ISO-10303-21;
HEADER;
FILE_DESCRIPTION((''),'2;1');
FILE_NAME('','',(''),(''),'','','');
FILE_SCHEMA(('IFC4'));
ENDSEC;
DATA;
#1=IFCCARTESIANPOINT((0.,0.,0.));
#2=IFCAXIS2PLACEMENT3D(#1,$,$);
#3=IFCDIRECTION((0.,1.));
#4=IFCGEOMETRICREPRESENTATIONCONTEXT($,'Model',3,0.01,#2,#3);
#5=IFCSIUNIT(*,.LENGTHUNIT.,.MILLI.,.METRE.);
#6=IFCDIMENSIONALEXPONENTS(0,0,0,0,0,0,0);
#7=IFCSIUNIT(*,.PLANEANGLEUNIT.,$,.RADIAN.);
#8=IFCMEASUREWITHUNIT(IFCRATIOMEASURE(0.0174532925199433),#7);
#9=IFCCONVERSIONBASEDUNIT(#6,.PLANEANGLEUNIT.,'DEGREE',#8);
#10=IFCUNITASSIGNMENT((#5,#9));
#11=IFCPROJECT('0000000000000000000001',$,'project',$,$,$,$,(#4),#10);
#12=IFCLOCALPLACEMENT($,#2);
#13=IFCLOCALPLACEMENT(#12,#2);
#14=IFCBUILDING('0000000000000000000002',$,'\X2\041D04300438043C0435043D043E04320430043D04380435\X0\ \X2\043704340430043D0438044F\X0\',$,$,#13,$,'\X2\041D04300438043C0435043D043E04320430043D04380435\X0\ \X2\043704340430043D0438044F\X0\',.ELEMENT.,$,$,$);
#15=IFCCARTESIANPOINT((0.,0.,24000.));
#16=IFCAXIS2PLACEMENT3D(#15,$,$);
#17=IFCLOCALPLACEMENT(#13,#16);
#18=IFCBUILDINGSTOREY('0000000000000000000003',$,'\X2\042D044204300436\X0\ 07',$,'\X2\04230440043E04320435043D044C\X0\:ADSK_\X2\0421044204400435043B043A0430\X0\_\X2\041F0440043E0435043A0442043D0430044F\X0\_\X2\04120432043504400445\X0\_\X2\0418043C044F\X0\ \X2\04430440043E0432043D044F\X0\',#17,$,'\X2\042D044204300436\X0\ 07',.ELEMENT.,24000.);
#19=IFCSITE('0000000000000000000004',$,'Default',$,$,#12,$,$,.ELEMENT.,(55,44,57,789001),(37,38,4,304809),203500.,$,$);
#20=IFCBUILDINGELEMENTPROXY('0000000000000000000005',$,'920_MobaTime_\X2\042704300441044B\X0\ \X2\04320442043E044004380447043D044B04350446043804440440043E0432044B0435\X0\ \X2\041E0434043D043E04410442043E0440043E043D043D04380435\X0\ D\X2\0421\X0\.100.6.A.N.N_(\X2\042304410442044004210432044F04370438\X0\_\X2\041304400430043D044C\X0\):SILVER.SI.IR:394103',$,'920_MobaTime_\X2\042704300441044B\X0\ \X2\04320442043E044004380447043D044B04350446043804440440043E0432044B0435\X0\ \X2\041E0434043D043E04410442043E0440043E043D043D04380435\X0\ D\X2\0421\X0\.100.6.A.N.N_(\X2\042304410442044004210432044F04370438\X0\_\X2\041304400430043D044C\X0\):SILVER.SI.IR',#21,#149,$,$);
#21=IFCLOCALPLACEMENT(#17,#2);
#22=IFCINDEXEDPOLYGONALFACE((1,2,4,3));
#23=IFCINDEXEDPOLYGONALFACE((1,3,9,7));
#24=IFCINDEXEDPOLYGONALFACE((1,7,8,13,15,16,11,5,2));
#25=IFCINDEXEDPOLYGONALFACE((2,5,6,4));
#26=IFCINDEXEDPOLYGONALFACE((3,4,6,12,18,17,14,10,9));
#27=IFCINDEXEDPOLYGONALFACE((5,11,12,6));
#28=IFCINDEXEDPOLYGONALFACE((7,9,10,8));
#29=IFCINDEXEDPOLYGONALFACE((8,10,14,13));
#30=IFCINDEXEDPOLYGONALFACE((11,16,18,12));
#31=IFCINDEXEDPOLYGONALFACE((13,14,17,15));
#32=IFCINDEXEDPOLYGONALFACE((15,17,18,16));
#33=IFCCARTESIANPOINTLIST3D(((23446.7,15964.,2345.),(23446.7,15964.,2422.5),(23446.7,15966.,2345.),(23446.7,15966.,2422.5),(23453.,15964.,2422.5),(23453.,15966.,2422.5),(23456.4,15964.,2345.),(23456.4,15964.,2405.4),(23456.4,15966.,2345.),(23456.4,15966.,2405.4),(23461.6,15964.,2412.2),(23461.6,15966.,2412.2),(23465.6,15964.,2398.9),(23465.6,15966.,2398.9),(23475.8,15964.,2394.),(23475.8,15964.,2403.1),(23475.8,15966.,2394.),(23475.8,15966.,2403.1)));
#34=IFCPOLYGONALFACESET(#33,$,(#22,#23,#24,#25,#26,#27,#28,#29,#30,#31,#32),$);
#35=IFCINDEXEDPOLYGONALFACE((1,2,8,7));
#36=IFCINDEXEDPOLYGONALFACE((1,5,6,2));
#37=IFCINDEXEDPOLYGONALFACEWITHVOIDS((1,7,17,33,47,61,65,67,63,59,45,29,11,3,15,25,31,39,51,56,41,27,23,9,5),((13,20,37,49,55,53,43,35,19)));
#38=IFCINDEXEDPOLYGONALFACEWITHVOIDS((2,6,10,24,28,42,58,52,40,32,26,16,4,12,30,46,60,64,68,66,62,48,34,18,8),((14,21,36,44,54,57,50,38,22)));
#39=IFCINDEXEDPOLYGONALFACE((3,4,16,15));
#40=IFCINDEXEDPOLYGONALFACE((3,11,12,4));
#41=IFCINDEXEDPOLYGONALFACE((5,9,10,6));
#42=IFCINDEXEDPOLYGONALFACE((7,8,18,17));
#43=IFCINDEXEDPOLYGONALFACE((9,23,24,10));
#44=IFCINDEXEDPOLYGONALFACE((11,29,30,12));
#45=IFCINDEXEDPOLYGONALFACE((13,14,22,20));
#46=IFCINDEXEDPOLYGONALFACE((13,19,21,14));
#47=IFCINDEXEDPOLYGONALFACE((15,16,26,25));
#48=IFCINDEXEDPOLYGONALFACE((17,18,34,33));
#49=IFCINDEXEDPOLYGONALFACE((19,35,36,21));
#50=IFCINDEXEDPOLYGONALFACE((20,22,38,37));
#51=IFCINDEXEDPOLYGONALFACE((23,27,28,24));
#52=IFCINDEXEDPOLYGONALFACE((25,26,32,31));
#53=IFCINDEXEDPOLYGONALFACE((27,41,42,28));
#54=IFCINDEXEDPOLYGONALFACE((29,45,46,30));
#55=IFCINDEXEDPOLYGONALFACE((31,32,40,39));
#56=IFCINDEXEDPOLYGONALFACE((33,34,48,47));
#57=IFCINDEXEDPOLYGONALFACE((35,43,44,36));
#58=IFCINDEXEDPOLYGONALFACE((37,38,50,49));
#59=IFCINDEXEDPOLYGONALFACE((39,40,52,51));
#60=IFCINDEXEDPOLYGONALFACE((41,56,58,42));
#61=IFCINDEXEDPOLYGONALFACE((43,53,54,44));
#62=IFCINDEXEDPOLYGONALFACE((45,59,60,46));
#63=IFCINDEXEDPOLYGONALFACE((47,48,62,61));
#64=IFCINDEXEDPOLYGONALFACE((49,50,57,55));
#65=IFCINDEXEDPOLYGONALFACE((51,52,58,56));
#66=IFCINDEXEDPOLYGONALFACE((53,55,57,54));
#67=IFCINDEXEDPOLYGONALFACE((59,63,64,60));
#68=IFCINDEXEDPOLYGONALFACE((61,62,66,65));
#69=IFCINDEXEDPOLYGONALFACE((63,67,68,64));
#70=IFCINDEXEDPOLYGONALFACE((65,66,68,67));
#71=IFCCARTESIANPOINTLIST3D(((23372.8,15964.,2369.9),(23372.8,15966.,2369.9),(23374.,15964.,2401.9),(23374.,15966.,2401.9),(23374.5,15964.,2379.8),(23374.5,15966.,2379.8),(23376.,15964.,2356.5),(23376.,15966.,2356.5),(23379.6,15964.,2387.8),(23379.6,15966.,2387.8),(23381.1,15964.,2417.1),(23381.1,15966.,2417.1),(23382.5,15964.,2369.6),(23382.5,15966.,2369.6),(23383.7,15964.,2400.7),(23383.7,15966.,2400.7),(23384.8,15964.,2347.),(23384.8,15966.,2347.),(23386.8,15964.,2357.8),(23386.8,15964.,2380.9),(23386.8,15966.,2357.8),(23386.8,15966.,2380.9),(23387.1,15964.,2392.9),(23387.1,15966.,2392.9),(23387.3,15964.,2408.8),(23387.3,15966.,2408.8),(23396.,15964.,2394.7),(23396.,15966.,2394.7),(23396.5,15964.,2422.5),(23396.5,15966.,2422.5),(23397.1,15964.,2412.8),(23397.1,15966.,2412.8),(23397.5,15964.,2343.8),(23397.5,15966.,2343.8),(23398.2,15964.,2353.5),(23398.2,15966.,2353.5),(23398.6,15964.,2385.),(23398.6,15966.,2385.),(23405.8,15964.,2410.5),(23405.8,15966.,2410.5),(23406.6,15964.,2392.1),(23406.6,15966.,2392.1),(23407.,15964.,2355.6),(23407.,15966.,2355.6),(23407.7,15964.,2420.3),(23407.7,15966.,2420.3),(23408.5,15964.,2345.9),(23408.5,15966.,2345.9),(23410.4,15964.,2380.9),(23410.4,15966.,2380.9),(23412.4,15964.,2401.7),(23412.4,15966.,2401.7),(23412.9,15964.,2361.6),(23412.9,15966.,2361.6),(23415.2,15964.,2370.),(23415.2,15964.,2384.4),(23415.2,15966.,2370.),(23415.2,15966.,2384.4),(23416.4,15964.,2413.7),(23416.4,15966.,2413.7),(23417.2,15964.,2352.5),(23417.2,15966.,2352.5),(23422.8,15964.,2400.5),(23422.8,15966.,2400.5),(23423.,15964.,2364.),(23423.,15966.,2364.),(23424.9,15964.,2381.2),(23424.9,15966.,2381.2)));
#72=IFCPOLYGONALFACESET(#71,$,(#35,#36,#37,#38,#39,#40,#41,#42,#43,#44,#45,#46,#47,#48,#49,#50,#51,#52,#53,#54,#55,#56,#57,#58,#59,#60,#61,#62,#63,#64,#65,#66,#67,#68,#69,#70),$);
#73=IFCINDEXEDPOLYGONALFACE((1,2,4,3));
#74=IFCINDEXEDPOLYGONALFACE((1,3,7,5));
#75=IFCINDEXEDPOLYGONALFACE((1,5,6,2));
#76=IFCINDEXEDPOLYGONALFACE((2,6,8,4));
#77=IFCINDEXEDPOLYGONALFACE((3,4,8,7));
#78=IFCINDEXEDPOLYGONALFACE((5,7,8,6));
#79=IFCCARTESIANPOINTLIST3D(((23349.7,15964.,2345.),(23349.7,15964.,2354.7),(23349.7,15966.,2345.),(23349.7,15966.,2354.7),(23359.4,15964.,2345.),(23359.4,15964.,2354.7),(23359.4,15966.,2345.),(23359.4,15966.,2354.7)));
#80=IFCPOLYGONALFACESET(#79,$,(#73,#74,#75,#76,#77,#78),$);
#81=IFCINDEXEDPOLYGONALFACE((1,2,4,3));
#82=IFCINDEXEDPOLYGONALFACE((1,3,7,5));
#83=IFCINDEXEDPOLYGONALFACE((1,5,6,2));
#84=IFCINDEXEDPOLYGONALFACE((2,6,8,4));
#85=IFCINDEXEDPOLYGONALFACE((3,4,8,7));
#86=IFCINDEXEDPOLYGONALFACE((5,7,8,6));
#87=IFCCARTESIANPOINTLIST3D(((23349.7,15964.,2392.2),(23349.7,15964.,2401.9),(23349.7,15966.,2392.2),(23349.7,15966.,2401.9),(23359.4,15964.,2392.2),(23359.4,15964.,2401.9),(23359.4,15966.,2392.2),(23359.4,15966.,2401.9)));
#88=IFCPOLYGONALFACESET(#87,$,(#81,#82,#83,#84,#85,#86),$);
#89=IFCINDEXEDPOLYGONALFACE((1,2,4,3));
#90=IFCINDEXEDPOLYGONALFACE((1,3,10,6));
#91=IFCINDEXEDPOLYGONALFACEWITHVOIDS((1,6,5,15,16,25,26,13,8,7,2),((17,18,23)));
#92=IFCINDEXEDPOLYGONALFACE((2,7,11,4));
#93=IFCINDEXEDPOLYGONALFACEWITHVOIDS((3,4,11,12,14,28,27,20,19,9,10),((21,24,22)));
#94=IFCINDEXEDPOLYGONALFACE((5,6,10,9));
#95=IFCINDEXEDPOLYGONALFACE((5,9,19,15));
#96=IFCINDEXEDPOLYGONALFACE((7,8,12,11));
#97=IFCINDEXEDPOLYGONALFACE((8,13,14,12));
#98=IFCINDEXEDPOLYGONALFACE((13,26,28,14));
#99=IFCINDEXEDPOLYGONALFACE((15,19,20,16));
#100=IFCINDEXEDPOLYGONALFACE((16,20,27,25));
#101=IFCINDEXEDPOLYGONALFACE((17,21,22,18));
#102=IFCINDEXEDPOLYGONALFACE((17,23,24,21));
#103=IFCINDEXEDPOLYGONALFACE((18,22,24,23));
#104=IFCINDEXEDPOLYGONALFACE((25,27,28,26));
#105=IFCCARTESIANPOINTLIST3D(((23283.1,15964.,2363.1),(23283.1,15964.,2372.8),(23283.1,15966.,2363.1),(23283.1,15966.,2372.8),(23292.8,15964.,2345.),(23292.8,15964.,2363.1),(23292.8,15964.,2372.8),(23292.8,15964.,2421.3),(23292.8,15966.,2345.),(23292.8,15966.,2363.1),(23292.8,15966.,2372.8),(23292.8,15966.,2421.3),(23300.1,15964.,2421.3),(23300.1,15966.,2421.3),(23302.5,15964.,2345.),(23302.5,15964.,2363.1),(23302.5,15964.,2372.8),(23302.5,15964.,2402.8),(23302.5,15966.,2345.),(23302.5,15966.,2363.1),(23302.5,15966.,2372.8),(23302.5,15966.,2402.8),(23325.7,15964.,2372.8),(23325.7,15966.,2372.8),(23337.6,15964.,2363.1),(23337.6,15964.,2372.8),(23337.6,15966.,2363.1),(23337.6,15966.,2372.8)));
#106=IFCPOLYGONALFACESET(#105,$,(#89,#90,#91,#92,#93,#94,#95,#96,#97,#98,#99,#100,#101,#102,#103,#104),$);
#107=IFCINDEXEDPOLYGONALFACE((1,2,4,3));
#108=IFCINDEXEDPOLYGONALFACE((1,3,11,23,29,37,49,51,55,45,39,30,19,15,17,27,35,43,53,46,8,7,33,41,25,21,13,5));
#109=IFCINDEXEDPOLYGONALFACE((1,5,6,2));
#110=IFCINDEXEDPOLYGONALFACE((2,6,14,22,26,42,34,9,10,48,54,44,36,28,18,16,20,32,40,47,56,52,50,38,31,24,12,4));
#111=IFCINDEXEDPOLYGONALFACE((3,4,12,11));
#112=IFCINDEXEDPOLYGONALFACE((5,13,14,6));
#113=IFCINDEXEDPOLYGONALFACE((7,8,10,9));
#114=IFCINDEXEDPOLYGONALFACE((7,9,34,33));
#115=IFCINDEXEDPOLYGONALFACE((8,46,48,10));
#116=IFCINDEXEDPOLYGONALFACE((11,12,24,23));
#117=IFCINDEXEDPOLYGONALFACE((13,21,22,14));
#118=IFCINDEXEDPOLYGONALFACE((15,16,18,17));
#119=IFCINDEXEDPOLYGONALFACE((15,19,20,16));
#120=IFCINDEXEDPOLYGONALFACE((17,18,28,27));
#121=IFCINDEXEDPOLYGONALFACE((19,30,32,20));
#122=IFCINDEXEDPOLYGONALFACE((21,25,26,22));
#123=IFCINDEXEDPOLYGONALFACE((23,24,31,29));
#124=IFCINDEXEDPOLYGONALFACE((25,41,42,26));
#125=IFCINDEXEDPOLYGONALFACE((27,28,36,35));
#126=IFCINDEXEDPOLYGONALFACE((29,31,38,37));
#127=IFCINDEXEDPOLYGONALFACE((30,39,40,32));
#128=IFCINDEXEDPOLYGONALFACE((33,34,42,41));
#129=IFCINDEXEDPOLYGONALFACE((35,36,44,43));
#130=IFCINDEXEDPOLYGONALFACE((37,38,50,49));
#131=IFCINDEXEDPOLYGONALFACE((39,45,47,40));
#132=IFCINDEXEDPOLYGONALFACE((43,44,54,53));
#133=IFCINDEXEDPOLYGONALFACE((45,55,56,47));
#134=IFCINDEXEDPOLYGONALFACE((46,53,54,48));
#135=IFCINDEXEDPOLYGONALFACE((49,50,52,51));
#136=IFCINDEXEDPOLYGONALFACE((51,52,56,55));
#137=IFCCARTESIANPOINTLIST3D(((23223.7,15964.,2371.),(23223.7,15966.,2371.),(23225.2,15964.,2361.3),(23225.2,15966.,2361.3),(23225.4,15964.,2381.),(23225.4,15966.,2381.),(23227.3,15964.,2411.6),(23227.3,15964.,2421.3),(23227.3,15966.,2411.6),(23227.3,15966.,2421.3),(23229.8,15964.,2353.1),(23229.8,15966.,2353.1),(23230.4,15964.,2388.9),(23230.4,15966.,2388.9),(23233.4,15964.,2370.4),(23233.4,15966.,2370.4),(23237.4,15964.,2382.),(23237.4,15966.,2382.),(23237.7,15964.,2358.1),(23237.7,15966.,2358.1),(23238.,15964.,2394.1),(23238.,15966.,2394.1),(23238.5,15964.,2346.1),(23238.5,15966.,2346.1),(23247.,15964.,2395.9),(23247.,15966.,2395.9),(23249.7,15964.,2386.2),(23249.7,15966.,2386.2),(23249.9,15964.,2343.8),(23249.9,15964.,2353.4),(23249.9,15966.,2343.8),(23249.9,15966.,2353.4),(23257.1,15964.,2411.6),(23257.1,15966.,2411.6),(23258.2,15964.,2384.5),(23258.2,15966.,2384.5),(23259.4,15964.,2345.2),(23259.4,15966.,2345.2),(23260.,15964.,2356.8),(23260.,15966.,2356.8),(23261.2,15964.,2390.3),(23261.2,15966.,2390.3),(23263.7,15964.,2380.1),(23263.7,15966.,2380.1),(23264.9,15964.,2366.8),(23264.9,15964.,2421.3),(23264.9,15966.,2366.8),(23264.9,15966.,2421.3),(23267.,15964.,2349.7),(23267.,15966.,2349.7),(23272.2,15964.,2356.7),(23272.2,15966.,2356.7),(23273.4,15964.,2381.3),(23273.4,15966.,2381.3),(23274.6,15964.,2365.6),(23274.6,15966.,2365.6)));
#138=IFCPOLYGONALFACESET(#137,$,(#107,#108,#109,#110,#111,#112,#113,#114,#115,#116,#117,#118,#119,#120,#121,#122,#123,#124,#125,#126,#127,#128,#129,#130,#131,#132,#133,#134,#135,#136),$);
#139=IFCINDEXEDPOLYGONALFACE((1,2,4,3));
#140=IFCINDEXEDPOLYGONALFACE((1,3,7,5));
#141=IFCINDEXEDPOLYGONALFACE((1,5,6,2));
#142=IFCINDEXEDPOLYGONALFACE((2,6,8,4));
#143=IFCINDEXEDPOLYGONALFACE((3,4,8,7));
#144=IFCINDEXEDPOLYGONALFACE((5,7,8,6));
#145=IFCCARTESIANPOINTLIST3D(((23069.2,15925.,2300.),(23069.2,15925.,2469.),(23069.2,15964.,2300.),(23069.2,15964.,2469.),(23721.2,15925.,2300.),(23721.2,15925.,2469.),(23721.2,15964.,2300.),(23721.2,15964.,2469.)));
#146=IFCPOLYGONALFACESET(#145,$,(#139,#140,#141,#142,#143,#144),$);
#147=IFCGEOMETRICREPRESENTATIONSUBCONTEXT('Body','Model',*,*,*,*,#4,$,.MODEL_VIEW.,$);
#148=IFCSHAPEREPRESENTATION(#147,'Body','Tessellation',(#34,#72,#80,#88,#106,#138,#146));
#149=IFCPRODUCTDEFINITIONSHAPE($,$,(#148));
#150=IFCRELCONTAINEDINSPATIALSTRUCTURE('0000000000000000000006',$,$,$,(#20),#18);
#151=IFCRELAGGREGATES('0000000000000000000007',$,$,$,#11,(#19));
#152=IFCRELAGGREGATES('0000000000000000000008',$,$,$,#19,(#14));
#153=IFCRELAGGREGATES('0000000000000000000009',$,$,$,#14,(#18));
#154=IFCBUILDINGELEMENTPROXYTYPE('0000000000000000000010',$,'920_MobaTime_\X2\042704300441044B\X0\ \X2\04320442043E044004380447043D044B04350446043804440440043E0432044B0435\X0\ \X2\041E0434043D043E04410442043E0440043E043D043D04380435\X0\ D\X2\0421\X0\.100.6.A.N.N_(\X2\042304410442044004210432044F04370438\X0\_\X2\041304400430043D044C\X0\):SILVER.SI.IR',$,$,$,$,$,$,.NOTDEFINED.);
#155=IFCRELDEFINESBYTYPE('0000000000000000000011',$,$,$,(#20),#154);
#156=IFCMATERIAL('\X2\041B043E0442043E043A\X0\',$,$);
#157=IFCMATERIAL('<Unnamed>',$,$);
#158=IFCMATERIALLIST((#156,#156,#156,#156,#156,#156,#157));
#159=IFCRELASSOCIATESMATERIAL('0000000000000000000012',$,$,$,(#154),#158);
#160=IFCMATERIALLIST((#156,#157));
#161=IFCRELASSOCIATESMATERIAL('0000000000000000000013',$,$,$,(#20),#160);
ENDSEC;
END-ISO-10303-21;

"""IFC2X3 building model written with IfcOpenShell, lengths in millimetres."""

from ifc_helpers import new_model, entity, si_unit, converted_unit, direction, frame, origin, origin_2d_with_axis, place, context, subcontext, project, spatial, polyline, rectangle, outline, extrude, source, transform, mapped, material, material_list, type_object, type_shapes, element, save


model = new_model("IFC2X3")

# Units and contexts
model_context = context("Model", 3, precision=0.01, world=origin(), true_north=direction((0.0, 1.0)))
body_context = subcontext(model_context, "Body", "Model", "MODEL_VIEW")
ifc_project = project(units=[si_unit("LENGTHUNIT", "METRE", prefix="MILLI"), converted_unit("PLANEANGLEUNIT", "DEGREE", entity("IfcRatioMeasure", 0.0174532925199433), si_unit("PLANEANGLEUNIT", "RADIAN"), dimensions=[0, 0, 0, 0, 0, 0, 0])], contexts=[model_context])

# Site, building, storey
site_placement = place(None, origin())
site = spatial("IfcSite", under=ifc_project, at=site_placement, Name="Default", CompositionType="ELEMENT", RefLatitude=(55, 44, 57, 789001), RefLongitude=(37, 38, 4, 304809), RefElevation=203500.0)
building_placement = place(site_placement, origin())
building = spatial("IfcBuilding", under=site, at=building_placement, Name="Наименование здания", LongName="Наименование здания", CompositionType="ELEMENT")
storey_placement = place(building_placement, frame((0.0, 0.0, 24000.0)))
storey = spatial("IfcBuildingStorey", under=building, at=storey_placement, Name="Этаж 07", ObjectType="Уровень:ADSK_Стрелка_Проектная_Вверх_Имя уровня", LongName="Этаж 07", CompositionType="ELEMENT", Elevation=24000.0)

# Building element proxy
ifc_material_1 = material(Name="Лоток")
ifc_material_2 = material(Name="<Unnamed>")
ifc_material_list_1 = material_list([ifc_material_1, ifc_material_2])
ifc_material_list_2 = material_list([ifc_material_1, ifc_material_1, ifc_material_1, ifc_material_1, ifc_material_1, ifc_material_1, ifc_material_2])
building_element_proxy_type = type_object("IfcBuildingElementProxyType", Name="920_MobaTime_Часы вторичныецифровые Односторонние DС.100.6.A.N.N_(УстрСвязи_Грань):SILVER.SI.IR", PredefinedType="NOTDEFINED", material=ifc_material_list_2)
shared_shape = source(origin(), body_context, "Body", "SweptSolid", [
    extrude(outline(polyline([(-49.3, -13.1), (28.2, -13.1), (28.2, -6.8), (17.9, 1.8), (8.8, 16.0), (-0.3, 16.0), (4.6, 5.8), (11.1, -3.4), (-49.3, -3.4), (-49.3, -13.1)])), frame((-64.6, 9.8, 39.0), z_axis=(0.0, 0.0, 1.0), x_axis=(0.0, 1.0, 0.0)), (0.0, 0.0, 1.0), 2.0),
    extrude(outline(polyline([(2.2, -27.6), (19.0, -27.6), (30.5, -16.1), (33.3, -4.9), (31.0, 5.8), (21.8, 17.2), (5.2, 27.3), (-11.1, 33.0), (-24.0, 32.7), (-33.6, 27.6), (-40.3, 18.6), (-42.8, 5.7), (-38.0, -6.3), (-27.2, -14.9), (-17.5, -17.7), (-8.2, -16.4), (-0.3, -11.9), (5.1, -4.5), (7.3, 6.2), (4.0, 17.2), (18.4, 7.3), (23.6, -2.4), (22.0, -11.4), (14.2, -18.4), (5.3, -18.3), (2.2, -27.6)]), holes=[polyline([(-9.0, 23.3), (-1.3, 14.3), (-2.5, 2.0), (-11.4, -7.0), (-23.4, -6.0), (-32.2, 2.9), (-31.2, 15.1), (-25.6, 22.1), (-17.5, 24.9), (-9.0, 23.3)])]), frame((-2.7, 3.6, 39.0), z_axis=(0.0, 0.0, 1.0), x_axis=(-0.427649, 0.903945, 0.0)), (0.0, 0.0, 1.0), 2.0),
    extrude(rectangle(XDim=9.7, YDim=9.7, at=origin_2d_with_axis()), frame((40.6, -34.7, 39.0)), (0.0, 0.0, 1.0), 2.0),
    extrude(rectangle(XDim=9.7, YDim=9.7, at=origin_2d_with_axis()), frame((40.6, 12.6, 39.0)), (0.0, 0.0, 1.0), 2.0),
    extrude(outline(polyline([(-0.9, -28.1), (8.8, -28.1), (8.8, -9.9), (18.5, -9.9), (18.5, -0.2), (8.8, -0.2), (8.8, 48.3), (1.5, 48.3), (-36.0, -0.2), (-36.0, -9.9), (-0.9, -9.9), (-0.9, -28.1)]), holes=[polyline([(-0.9, -0.2), (-24.1, -0.2), (-0.9, 29.7), (-0.9, -0.2)])]), frame((93.6, -11.4, 39.0)), (0.0, 0.0, 1.0), 2.0),
    extrude(outline(polyline([(3.3, -28.3), (12.5, -28.3), (20.5, -25.0), (26.8, -18.9), (30.7, -10.0), (31.4, 1.6), (26.9, 11.8), (20.1, 18.4), (11.1, 22.3), (1.0, 23.3), (-7.9, 20.4), (-14.9, 14.5), (-18.9, 6.2), (-17.1, -9.0), (-36.7, 0.5), (-29.1, 29.2), (-38.5, 31.7), (-48.1, -4.6), (-11.6, -23.1), (-8.0, -14.0), (-10.8, -7.6), (-10.2, 1.1), (-3.0, 11.8), (9.2, 12.8), (20.0, 5.5), (21.4, -7.5), (15.5, -16.4), (4.6, -18.6), (3.3, -28.3)])), frame((147.1, -8.5, 39.0), z_axis=(0.0, 0.0, 1.0), x_axis=(0.256974, -0.966418, 0.0)), (0.0, 0.0, 1.0), 2.0),
    extrude(rectangle(XDim=652.0, YDim=169.0, at=origin_2d_with_axis()), frame((0.0, 0.0, 0.0), z_axis=(0.0, 0.0, 1.0), x_axis=(-1.0, 0.0, 0.0)), (0.0, 0.0, 1.0), 39.0),
])
type_shapes(building_element_proxy_type, [shared_shape])
for number, where, z_axis, x_axis, name in (
    (1, (23395.2, 15925.0, 2384.5), (0.0, 1.0, 0.0), (-1.0, 0.0, 0.0), "920_MobaTime_Часы вторичныецифровые Односторонние DС.100.6.A.N.N_(УстрСвязи_Грань):SILVER.SI.IR:394103"),
):
    element("IfcBuildingElementProxy", number, at=place(storey_placement, frame(where, z_axis=z_axis, x_axis=x_axis)), inside=storey, type_object=building_element_proxy_type, material=ifc_material_list_1, Name=name, ObjectType="920_MobaTime_Часы вторичныецифровые Односторонние DС.100.6.A.N.N_(УстрСвязи_Грань):SILVER.SI.IR", context=body_context, shape_type="MappedRepresentation", body=[
        mapped(shared_shape, transform((0.0, 0.0, 0.0), scale=1.0)),
    ])

save(model, "model.ifc")
